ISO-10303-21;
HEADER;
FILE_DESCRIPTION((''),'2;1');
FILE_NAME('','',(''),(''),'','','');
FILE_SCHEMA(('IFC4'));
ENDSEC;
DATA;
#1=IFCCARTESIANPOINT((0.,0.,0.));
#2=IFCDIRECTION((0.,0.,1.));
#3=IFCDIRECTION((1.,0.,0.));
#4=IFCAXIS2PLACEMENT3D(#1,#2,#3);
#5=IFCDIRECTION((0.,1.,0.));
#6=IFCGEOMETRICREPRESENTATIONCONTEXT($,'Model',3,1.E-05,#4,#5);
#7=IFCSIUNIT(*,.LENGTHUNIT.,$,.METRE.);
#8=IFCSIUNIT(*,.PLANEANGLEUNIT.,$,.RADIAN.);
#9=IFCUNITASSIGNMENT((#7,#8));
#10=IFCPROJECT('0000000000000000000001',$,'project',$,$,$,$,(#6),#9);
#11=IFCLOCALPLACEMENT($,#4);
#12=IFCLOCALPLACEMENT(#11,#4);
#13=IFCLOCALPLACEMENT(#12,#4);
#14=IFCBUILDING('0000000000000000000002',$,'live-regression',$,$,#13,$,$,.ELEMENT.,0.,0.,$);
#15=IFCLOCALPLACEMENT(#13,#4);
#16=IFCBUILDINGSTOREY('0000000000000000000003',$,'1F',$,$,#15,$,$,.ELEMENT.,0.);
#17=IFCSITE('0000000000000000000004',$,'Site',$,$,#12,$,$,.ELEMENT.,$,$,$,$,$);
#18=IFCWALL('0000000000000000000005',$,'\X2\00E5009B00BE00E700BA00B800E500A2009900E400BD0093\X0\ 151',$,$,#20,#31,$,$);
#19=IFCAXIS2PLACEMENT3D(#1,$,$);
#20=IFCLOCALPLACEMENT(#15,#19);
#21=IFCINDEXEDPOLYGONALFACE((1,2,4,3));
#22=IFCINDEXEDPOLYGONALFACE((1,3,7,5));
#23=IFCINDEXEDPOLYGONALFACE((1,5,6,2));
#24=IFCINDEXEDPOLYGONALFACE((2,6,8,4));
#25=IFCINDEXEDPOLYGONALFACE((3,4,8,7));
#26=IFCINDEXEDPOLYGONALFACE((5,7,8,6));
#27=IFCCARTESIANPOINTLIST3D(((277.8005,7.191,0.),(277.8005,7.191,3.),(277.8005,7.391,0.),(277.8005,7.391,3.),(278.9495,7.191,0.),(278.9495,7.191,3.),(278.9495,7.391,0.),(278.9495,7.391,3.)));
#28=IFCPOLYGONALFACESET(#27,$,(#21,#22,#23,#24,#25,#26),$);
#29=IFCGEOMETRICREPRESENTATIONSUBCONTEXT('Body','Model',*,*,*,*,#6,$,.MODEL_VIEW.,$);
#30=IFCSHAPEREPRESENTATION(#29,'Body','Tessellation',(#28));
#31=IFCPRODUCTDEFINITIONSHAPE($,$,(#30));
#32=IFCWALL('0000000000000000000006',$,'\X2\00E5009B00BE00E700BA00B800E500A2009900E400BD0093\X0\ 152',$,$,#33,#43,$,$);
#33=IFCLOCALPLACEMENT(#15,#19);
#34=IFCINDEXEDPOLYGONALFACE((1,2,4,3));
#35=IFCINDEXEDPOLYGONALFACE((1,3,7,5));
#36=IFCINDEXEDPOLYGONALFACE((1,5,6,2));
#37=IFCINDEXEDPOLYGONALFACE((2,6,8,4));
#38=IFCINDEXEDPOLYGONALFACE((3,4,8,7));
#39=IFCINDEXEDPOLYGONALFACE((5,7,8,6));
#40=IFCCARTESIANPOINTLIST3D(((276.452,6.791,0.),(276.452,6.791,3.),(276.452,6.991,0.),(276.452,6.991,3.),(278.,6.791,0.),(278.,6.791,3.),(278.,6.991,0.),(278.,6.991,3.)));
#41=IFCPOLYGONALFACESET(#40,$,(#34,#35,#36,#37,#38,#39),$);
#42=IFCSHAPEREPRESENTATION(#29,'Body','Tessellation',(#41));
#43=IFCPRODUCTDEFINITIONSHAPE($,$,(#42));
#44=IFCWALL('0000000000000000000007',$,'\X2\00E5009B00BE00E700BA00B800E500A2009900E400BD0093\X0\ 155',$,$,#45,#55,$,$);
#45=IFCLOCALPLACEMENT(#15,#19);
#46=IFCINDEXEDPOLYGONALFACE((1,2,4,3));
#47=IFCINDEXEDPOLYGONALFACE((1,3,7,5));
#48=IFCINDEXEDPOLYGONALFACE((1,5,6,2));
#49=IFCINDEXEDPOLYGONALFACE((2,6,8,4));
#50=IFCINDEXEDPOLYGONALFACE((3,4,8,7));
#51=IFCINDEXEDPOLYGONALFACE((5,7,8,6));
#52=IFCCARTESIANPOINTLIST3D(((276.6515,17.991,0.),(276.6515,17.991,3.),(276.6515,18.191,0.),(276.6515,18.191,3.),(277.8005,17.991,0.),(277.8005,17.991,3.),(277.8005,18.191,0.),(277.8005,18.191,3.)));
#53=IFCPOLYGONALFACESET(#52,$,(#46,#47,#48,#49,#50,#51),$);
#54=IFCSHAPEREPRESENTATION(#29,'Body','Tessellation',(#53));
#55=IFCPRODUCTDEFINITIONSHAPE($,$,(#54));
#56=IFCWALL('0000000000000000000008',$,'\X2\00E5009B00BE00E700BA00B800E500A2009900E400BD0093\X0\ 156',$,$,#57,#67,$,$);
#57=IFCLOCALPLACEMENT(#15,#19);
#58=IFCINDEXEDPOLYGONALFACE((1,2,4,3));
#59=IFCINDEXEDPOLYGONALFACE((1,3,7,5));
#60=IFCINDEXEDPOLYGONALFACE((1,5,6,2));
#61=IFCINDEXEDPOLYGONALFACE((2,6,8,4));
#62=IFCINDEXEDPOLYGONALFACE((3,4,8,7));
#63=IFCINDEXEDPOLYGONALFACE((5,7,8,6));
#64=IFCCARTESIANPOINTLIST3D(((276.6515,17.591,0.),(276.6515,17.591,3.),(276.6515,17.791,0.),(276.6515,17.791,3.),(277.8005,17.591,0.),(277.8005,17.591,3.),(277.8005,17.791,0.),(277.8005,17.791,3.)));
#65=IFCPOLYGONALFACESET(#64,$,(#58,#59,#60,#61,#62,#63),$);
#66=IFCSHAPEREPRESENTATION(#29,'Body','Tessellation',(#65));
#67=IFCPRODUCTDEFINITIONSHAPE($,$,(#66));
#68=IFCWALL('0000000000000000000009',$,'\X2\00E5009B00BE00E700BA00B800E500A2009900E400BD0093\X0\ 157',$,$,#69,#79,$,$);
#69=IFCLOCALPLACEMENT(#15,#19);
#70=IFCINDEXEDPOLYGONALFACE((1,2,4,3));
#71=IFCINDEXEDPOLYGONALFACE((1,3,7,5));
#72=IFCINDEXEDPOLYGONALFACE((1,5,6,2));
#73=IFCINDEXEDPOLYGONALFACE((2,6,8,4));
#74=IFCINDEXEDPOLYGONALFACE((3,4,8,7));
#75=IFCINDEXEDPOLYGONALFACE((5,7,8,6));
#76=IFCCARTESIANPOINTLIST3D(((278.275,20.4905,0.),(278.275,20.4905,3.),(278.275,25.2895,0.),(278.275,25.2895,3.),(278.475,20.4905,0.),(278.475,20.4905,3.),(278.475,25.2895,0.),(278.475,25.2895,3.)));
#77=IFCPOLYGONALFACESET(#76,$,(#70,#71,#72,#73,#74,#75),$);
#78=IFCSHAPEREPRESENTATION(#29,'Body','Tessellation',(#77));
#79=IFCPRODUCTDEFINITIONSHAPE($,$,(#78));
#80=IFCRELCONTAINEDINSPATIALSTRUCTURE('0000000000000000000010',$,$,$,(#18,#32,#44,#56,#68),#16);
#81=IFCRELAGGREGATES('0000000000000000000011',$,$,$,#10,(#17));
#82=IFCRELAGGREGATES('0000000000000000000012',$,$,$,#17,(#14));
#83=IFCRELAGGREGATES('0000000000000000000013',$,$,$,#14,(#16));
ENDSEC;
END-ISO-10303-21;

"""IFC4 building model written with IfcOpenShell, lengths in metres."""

from ifc_helpers import new_model, si_unit, direction, frame, frame_2d, origin_with_axes, place, context, subcontext, project, spatial, rectangle, extrude, element, save


model = new_model("IFC4")

# Units and contexts
model_context = context("Model", 3, precision=1e-05, world=origin_with_axes(), true_north=direction((0.0, 1.0, 0.0)))
body_context = subcontext(model_context, "Body", "Model", "MODEL_VIEW")
ifc_project = project(units=[si_unit("LENGTHUNIT", "METRE"), si_unit("PLANEANGLEUNIT", "RADIAN")], contexts=[model_context])

# Site, building, storey
placement = place(None, origin_with_axes())
site_placement = place(placement, origin_with_axes())
site = spatial("IfcSite", under=ifc_project, at=site_placement, Name="Site", CompositionType="ELEMENT")
building_placement = place(site_placement, origin_with_axes())
building = spatial("IfcBuilding", under=site, at=building_placement, Name="live-regression", CompositionType="ELEMENT", ElevationOfRefHeight=0.0, ElevationOfTerrain=0.0)
storey_placement = place(building_placement, origin_with_axes())
storey = spatial("IfcBuildingStorey", under=building, at=storey_placement, Name="1F", CompositionType="ELEMENT", Elevation=0.0)

# Walls
wall_1_placement = place(storey_placement, frame((278.375, 7.291, 0.0), z_axis=(0.0, 0.0, 1.0), x_axis=(-1.0, 0.0, 0.0)))
element("IfcWall", 1, at=wall_1_placement, inside=storey, Name="å\u009b¾çº¸å¢\u0099ä½\u0093 151", context=body_context, shape_type="SweptSolid", body=[
    extrude(rectangle(XDim=1.149, YDim=0.2, at=frame_2d((0.0, 0.0), x_axis=(1.0, 0.0, 0.0))), frame((0.0, 0.0, 0.0), z_axis=(0.0, 0.0, 1.0)), (0.0, 0.0, 1.0), 3.0),
])
wall_2_placement = place(storey_placement, frame((277.226, 6.891, 0.0), z_axis=(0.0, 0.0, 1.0), x_axis=(1.0, 0.0, 0.0)))
element("IfcWall", 2, at=wall_2_placement, inside=storey, Name="å\u009b¾çº¸å¢\u0099ä½\u0093 152", context=body_context, shape_type="SweptSolid", body=[
    extrude(rectangle(XDim=1.548, YDim=0.2, at=frame_2d((0.0, 0.0), x_axis=(1.0, 0.0, 0.0))), frame((0.0, 0.0, 0.0), z_axis=(0.0, 0.0, 1.0)), (0.0, 0.0, 1.0), 3.0),
])
for number, where, z_axis, x_axis, name in (
    (3, (277.226, 18.091, 0.0), (0.0, 0.0, 1.0), (1.0, 0.0, 0.0), "å\u009b¾çº¸å¢\u0099ä½\u0093 155"),
    (4, (277.226, 17.691, 0.0), (0.0, 0.0, 1.0), (1.0, 0.0, 0.0), "å\u009b¾çº¸å¢\u0099ä½\u0093 156"),
):
    element("IfcWall", number, at=place(storey_placement, frame(where, z_axis=z_axis, x_axis=x_axis)), inside=storey, Name=name, context=body_context, shape_type="SweptSolid", body=[
        extrude(rectangle(XDim=1.149, YDim=0.2, at=frame_2d((0.0, 0.0), x_axis=(1.0, 0.0, 0.0))), frame((0.0, 0.0, 0.0), z_axis=(0.0, 0.0, 1.0)), (0.0, 0.0, 1.0), 3.0),
    ])
wall_3_placement = place(storey_placement, frame((278.375, 22.89, 0.0), z_axis=(0.0, 0.0, 1.0), x_axis=(0.0, -1.0, 0.0)))
element("IfcWall", 5, at=wall_3_placement, inside=storey, Name="å\u009b¾çº¸å¢\u0099ä½\u0093 157", context=body_context, shape_type="SweptSolid", body=[
    extrude(rectangle(XDim=4.799, YDim=0.2, at=frame_2d((0.0, 0.0), x_axis=(1.0, 0.0, 0.0))), frame((0.0, 0.0, 0.0), z_axis=(0.0, 0.0, 1.0)), (0.0, 0.0, 1.0), 3.0),
])

save(model, "model.ifc")
